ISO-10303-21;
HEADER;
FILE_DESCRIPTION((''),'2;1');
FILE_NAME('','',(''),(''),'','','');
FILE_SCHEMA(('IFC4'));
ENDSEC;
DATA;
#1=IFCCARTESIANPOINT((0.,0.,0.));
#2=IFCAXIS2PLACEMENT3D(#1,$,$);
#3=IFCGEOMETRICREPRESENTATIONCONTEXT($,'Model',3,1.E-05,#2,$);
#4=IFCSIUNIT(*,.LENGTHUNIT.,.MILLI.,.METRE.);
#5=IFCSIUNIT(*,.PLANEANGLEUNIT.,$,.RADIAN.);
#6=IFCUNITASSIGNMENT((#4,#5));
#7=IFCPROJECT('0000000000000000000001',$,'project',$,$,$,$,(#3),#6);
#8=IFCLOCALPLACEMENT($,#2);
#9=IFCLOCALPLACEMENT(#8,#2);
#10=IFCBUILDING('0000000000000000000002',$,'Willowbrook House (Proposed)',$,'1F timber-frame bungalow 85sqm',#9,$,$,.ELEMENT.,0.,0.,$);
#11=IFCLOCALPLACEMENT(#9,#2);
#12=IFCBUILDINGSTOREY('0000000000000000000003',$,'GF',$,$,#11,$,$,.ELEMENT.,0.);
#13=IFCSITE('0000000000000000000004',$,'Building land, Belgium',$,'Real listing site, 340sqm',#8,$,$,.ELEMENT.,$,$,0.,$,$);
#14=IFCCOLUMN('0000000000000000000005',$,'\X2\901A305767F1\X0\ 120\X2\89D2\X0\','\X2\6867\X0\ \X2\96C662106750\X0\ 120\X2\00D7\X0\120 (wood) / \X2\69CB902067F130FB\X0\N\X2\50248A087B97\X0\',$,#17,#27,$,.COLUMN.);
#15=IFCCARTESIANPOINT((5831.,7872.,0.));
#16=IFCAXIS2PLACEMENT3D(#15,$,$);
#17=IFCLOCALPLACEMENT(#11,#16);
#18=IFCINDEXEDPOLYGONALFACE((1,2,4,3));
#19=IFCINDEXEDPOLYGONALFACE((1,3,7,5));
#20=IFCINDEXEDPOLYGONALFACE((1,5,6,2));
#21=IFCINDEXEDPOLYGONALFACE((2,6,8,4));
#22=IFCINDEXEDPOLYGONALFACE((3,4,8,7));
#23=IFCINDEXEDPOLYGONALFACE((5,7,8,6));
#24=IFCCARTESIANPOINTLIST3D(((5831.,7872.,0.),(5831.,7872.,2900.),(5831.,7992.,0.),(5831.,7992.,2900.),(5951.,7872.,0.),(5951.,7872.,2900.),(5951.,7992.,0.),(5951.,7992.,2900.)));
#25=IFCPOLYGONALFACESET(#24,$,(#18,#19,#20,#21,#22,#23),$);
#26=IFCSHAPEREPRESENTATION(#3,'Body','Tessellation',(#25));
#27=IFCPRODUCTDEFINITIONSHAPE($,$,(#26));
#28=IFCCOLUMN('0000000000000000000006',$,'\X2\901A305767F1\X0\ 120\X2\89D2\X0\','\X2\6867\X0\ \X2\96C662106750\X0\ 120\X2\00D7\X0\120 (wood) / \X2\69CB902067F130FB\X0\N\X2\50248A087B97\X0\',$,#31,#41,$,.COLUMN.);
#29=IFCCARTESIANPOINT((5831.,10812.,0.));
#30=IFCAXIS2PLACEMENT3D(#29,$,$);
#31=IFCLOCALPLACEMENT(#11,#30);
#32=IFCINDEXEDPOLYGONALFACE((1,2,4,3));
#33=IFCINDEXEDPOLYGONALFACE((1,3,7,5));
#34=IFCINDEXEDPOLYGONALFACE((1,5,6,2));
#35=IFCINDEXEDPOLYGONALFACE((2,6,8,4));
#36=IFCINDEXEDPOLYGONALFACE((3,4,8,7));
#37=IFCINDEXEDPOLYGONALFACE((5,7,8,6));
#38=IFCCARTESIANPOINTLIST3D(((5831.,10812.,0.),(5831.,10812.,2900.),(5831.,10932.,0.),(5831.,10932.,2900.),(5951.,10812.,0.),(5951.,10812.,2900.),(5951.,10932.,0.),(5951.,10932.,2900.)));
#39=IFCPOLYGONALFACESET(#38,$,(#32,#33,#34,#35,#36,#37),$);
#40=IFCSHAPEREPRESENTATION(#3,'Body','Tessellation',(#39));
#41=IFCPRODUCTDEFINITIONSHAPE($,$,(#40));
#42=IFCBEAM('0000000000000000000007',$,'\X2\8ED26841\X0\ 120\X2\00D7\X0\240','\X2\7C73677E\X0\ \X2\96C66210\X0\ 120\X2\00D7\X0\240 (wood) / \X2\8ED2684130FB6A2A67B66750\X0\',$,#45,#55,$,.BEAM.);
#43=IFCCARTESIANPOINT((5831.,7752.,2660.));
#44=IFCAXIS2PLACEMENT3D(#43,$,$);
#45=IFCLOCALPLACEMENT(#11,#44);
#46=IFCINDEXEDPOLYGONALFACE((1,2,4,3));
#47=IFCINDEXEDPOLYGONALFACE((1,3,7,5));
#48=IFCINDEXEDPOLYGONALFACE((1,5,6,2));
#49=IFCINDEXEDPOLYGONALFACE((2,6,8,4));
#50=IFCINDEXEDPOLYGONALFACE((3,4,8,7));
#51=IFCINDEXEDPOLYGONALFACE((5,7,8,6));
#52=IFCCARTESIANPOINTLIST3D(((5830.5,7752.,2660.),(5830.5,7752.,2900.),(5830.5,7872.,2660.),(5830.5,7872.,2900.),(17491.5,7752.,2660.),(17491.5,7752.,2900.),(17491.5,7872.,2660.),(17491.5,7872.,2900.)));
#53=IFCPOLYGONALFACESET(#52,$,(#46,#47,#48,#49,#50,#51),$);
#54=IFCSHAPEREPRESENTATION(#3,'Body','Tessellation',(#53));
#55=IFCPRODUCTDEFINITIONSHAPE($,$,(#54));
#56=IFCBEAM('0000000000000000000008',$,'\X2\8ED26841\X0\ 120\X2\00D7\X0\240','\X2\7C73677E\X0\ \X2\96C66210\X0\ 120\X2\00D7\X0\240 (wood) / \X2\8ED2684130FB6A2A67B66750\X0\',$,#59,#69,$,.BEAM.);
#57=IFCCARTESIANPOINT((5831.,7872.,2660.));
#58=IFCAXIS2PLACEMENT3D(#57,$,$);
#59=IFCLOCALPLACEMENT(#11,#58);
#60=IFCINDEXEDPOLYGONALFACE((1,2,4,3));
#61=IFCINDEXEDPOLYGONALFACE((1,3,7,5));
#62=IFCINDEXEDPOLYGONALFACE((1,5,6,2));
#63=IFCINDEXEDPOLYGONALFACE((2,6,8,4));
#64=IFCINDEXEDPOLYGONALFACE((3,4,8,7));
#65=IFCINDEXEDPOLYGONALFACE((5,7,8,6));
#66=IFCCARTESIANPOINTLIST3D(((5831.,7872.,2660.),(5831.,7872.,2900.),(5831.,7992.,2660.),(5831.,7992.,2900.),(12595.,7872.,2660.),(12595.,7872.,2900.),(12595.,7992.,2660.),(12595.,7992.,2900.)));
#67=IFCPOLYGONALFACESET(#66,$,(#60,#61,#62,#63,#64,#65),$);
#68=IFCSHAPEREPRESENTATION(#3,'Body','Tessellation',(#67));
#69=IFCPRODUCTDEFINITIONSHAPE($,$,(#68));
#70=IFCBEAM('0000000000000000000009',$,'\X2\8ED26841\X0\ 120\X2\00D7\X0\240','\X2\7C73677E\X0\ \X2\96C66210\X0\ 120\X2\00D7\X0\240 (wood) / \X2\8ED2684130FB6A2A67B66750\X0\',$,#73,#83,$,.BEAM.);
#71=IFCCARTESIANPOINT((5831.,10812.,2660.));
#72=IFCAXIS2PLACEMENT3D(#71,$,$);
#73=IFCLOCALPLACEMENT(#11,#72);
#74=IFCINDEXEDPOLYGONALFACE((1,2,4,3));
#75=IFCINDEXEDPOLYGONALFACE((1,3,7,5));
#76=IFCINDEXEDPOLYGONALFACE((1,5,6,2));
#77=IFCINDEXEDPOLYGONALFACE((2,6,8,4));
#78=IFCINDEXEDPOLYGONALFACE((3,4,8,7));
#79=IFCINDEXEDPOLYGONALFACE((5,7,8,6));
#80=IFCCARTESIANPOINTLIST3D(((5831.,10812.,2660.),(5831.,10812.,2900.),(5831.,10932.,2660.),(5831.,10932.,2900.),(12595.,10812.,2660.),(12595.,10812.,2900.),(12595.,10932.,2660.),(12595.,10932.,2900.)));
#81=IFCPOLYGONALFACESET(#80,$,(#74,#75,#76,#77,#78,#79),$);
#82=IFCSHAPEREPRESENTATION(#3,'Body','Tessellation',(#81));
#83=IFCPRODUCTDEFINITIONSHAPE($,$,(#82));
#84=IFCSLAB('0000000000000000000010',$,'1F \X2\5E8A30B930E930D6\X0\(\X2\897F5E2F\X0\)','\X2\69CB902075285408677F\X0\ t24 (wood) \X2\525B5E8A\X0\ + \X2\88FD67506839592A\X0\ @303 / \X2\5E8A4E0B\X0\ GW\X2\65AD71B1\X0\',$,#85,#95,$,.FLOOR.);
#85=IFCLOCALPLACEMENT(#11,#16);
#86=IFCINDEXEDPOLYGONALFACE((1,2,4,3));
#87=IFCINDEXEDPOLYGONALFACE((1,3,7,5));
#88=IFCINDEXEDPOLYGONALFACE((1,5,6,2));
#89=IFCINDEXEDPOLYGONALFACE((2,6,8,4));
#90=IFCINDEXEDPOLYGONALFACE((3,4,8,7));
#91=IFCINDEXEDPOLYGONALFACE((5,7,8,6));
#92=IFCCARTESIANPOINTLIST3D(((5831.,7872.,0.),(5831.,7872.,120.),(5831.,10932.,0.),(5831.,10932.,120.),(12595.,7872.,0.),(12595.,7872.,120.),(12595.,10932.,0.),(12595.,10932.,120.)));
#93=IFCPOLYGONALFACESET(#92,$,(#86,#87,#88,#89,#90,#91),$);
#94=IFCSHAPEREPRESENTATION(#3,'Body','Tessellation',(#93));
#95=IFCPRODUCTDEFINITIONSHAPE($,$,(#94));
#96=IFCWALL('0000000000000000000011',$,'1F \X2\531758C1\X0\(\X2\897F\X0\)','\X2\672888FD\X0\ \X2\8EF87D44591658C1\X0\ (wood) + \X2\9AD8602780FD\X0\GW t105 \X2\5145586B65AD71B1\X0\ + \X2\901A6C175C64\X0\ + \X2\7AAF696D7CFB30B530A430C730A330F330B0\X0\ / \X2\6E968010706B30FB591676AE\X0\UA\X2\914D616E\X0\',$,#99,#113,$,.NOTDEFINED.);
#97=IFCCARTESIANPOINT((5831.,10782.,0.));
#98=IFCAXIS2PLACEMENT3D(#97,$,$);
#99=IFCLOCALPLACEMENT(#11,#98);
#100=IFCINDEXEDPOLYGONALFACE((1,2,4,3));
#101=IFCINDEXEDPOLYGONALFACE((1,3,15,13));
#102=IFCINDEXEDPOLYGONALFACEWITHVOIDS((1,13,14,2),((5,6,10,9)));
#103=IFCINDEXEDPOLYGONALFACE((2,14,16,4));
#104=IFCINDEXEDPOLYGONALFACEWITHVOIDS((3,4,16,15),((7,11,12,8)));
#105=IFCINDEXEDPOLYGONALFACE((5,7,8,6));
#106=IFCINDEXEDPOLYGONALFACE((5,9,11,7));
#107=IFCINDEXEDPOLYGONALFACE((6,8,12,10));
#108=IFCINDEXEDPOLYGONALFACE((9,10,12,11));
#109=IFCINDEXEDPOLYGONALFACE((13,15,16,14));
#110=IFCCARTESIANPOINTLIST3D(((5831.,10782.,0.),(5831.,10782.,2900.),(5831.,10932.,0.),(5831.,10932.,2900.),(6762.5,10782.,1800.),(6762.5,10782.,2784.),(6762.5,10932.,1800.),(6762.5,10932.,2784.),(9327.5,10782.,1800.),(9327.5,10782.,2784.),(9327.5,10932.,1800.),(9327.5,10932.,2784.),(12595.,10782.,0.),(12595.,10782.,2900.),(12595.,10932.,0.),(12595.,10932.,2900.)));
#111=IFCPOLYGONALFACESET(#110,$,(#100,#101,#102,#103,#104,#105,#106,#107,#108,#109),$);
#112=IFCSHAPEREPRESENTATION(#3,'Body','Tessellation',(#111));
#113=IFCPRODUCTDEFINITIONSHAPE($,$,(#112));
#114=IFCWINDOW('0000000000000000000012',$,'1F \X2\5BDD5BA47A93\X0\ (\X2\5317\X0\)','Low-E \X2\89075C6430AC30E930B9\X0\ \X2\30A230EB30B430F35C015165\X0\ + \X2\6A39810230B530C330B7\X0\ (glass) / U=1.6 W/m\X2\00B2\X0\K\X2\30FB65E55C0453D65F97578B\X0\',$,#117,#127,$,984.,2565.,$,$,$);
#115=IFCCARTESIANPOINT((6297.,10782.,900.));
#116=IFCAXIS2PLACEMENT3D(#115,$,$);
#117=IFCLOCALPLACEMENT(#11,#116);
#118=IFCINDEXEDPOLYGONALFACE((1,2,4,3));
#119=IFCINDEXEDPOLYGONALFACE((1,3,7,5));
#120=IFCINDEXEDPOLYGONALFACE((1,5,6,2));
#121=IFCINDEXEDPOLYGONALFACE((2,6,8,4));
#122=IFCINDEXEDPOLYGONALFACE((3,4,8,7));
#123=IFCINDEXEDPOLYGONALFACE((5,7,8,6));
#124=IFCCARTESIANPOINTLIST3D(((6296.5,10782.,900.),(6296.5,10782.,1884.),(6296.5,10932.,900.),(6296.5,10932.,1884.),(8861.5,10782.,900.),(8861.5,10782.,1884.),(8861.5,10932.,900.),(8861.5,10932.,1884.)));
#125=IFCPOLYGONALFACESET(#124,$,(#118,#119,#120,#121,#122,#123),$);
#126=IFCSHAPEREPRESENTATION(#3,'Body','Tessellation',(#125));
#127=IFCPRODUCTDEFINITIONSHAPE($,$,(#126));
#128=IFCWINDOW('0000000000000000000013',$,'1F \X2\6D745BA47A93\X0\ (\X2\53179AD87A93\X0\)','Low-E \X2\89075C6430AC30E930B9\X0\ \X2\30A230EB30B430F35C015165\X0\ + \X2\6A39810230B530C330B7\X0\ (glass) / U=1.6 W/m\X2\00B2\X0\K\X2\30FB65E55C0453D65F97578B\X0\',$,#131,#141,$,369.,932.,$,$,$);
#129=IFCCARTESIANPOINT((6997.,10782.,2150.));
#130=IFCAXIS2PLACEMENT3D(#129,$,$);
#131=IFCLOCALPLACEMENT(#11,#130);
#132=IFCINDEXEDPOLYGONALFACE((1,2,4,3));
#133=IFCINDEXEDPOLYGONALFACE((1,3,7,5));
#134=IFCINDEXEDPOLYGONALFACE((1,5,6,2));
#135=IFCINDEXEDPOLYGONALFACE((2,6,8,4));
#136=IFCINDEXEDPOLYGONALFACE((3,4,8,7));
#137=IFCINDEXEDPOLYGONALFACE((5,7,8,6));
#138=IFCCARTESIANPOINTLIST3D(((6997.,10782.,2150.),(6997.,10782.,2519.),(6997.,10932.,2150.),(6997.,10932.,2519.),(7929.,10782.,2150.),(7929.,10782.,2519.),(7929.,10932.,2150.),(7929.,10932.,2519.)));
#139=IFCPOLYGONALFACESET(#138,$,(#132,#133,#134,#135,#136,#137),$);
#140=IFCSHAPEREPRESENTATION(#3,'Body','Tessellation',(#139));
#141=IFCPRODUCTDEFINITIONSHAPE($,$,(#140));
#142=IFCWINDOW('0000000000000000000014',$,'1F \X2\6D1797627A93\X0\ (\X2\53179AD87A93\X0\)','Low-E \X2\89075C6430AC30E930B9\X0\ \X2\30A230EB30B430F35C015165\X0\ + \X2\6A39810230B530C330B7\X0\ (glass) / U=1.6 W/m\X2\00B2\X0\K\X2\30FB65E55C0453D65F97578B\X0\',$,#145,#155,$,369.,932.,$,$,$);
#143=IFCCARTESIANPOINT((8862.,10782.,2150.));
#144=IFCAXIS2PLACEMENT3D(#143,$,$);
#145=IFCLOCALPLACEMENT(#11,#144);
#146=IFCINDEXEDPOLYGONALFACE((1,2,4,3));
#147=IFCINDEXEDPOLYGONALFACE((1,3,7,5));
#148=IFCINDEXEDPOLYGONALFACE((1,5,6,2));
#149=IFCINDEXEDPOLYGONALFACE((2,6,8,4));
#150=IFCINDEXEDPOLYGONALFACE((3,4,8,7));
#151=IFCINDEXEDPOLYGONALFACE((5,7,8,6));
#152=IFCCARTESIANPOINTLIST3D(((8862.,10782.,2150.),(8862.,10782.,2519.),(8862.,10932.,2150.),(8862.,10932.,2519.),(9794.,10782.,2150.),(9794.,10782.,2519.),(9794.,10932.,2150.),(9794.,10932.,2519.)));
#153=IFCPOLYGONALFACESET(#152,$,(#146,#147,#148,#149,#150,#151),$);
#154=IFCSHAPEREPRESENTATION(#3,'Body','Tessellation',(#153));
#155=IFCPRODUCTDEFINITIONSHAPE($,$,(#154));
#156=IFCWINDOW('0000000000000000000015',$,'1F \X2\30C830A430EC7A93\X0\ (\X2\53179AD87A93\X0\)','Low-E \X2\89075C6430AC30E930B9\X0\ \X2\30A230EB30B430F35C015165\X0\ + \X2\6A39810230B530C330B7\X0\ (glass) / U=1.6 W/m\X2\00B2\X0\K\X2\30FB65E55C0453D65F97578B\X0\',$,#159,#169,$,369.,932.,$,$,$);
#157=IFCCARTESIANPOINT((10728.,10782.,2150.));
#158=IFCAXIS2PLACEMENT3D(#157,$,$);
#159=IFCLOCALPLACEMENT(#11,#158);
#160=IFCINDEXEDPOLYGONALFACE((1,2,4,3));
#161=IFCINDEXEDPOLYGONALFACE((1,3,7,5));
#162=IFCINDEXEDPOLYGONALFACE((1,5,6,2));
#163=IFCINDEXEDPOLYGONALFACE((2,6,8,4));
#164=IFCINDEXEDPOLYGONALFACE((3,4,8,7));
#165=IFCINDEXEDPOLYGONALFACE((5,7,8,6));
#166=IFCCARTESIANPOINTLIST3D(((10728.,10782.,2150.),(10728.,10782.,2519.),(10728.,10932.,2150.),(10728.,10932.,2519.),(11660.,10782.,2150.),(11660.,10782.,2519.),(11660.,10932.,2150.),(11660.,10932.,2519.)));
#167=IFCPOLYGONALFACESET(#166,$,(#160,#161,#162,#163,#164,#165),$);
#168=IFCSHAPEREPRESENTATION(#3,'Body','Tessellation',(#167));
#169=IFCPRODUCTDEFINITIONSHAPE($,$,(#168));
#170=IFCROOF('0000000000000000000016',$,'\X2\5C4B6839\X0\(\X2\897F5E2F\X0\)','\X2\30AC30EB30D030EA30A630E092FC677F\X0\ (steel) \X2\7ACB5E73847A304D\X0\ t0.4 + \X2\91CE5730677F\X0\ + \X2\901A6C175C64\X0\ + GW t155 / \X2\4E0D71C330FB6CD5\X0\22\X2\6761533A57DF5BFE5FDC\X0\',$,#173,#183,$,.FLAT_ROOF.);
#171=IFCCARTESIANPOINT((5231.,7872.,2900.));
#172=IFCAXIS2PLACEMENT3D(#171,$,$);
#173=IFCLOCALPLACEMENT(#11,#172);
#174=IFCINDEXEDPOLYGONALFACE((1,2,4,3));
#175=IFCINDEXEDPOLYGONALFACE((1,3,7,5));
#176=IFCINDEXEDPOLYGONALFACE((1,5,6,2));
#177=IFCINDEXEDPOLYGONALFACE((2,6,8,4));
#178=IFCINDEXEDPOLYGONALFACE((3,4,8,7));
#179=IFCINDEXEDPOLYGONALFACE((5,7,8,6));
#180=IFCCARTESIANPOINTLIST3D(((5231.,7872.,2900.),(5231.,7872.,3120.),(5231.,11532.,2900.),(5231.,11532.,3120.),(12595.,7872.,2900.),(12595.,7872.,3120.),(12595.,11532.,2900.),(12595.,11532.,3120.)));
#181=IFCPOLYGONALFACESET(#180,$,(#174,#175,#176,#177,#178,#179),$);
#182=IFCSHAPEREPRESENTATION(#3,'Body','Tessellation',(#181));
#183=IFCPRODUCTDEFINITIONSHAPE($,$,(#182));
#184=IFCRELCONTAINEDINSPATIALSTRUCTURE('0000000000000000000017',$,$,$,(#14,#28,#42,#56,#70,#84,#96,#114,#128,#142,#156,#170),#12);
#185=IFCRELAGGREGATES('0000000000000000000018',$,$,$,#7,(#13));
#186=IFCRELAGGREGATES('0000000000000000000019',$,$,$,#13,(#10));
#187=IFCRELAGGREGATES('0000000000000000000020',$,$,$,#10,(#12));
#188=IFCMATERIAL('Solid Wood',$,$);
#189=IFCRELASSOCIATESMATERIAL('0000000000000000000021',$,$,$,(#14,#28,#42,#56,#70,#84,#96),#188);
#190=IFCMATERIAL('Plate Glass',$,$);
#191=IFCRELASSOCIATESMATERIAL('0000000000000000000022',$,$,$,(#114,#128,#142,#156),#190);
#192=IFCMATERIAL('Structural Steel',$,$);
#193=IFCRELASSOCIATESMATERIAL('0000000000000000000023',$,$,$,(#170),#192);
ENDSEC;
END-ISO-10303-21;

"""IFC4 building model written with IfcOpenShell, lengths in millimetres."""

from ifc_helpers import new_model, si_unit, frame, frame_2d, origin, place, context, project, spatial, rectangle, extrude, material, element, fill, save


model = new_model("IFC4")

# Units and contexts
model_context = context("Model", 3, precision=1e-05, world=origin())
ifc_project = project(units=[si_unit("LENGTHUNIT", "METRE", prefix="MILLI"), si_unit("PLANEANGLEUNIT", "RADIAN")], contexts=[model_context])

# Site, building, storey
site_placement = place(None, origin())
site = spatial("IfcSite", under=ifc_project, at=site_placement, Name="Building land, Belgium", ObjectType="Real listing site, 340sqm", CompositionType="ELEMENT", RefElevation=0.0)
building_placement = place(site_placement, origin())
building = spatial("IfcBuilding", under=site, at=building_placement, Name="Willowbrook House (Proposed)", ObjectType="1F timber-frame bungalow 85sqm", CompositionType="ELEMENT", ElevationOfRefHeight=0.0, ElevationOfTerrain=0.0)
storey_placement = place(building_placement, origin())
storey = spatial("IfcBuildingStorey", under=building, at=storey_placement, Name="GF", CompositionType="ELEMENT", Elevation=0.0)

# Columns
ifc_material_1 = material(Name="Solid Wood")
column_1_placement = place(storey_placement, frame((5831.0, 7872.0, 0.0)))
element("IfcColumn", 1, at=column_1_placement, inside=storey, material=ifc_material_1, Name="通し柱 120角", Description="桧 集成材 120×120 (wood) / 構造柱・N値計算", PredefinedType="COLUMN", context=model_context, shape_type="SweptSolid", body=[
    extrude(rectangle(XDim=120.0, YDim=120.0, at=frame_2d((60.0, 60.0))), frame((5831.0, 7872.0, 0.0)), (0.0, 0.0, 1.0), 2900.0),
])
column_2_placement = place(storey_placement, frame((5831.0, 10812.0, 0.0)))
element("IfcColumn", 2, at=column_2_placement, inside=storey, material=ifc_material_1, Name="通し柱 120角", Description="桧 集成材 120×120 (wood) / 構造柱・N値計算", PredefinedType="COLUMN", context=model_context, shape_type="SweptSolid", body=[
    extrude(rectangle(XDim=120.0, YDim=120.0, at=frame_2d((60.0, 60.0))), frame((5831.0, 10812.0, 0.0)), (0.0, 0.0, 1.0), 2900.0),
])

# Beams
beam_1_placement = place(storey_placement, frame((5831.0, 7752.0, 2660.0)))
element("IfcBeam", 3, at=beam_1_placement, inside=storey, material=ifc_material_1, Name="軒桁 120×240", Description="米松 集成 120×240 (wood) / 軒桁・横架材", PredefinedType="BEAM", context=model_context, shape_type="SweptSolid", body=[
    extrude(rectangle(XDim=11661.0, YDim=120.0, at=frame_2d((5830.0, 60.0))), frame((5831.0, 7752.0, 2660.0)), (0.0, 0.0, 1.0), 240.0),
])
beam_2_placement = place(storey_placement, frame((5831.0, 7872.0, 2660.0)))
element("IfcBeam", 4, at=beam_2_placement, inside=storey, material=ifc_material_1, Name="軒桁 120×240", Description="米松 集成 120×240 (wood) / 軒桁・横架材", PredefinedType="BEAM", context=model_context, shape_type="SweptSolid", body=[
    extrude(rectangle(XDim=6764.0, YDim=120.0, at=frame_2d((3382.0, 60.0))), frame((5831.0, 7872.0, 2660.0)), (0.0, 0.0, 1.0), 240.0),
])
beam_3_placement = place(storey_placement, frame((5831.0, 10812.0, 2660.0)))
element("IfcBeam", 5, at=beam_3_placement, inside=storey, material=ifc_material_1, Name="軒桁 120×240", Description="米松 集成 120×240 (wood) / 軒桁・横架材", PredefinedType="BEAM", context=model_context, shape_type="SweptSolid", body=[
    extrude(rectangle(XDim=6764.0, YDim=120.0, at=frame_2d((3382.0, 60.0))), frame((5831.0, 10812.0, 2660.0)), (0.0, 0.0, 1.0), 240.0),
])

# Slab
slab_placement = place(storey_placement, frame((5831.0, 7872.0, 0.0)))
element("IfcSlab", 6, at=slab_placement, inside=storey, material=ifc_material_1, Name="1F 床スラブ(西帯)", Description="構造用合板 t24 (wood) 剛床 + 製材根太 @303 / 床下 GW断熱", PredefinedType="FLOOR", context=model_context, shape_type="SweptSolid", body=[
    extrude(rectangle(XDim=6764.0, YDim=3060.0, at=frame_2d((3382.0, 1530.0))), frame((5831.0, 7872.0, 0.0)), (0.0, 0.0, 1.0), 120.0),
])

# Wall, openings, windows
wall_1_placement = place(storey_placement, frame((5831.0, 10782.0, 0.0)))
wall_1 = element("IfcWall", 7, at=wall_1_placement, inside=storey, material=ifc_material_1, Name="1F 北壁(西)", Description="木製 軸組外壁 (wood) + 高性能GW t105 充填断熱 + 通気層 + 窯業系サイディング / 準耐火・外皮UA配慮", PredefinedType="NOTDEFINED", context=model_context, shape_type="SweptSolid", body=[
    extrude(rectangle(XDim=6764.0, YDim=150.0, at=frame_2d((3382.0, 75.0))), frame((5831.0, 10782.0, 0.0)), (0.0, 0.0, 1.0), 2900.0),
])
opening_1_placement = place(storey_placement, frame((6297.0, 10782.0, 900.0)))
opening_1 = element("IfcOpeningElement", 8, at=opening_1_placement, cuts=wall_1, PredefinedType="NOTDEFINED", context=model_context, shape_type="SweptSolid", body=[
    extrude(rectangle(XDim=2565.0, YDim=150.0, at=frame_2d((1282.0, 75.0))), frame((6297.0, 10782.0, 900.0)), (0.0, 0.0, 1.0), 984.0),
])
opening_2_placement = place(storey_placement, frame((6997.0, 10782.0, 2150.0)))
opening_2 = element("IfcOpeningElement", 9, at=opening_2_placement, cuts=wall_1, PredefinedType="NOTDEFINED", context=model_context, shape_type="SweptSolid", body=[
    extrude(rectangle(XDim=932.0, YDim=150.0, at=frame_2d((466.0, 75.0))), frame((6997.0, 10782.0, 2150.0)), (0.0, 0.0, 1.0), 369.0),
])
opening_3_placement = place(storey_placement, frame((8862.0, 10782.0, 2150.0)))
opening_3 = element("IfcOpeningElement", 10, at=opening_3_placement, cuts=wall_1, PredefinedType="NOTDEFINED", context=model_context, shape_type="SweptSolid", body=[
    extrude(rectangle(XDim=932.0, YDim=150.0, at=frame_2d((466.0, 75.0))), frame((8862.0, 10782.0, 2150.0)), (0.0, 0.0, 1.0), 369.0),
])
opening_4_placement = place(storey_placement, frame((10728.0, 10782.0, 2150.0)))
opening_4 = element("IfcOpeningElement", 11, at=opening_4_placement, cuts=wall_1, PredefinedType="NOTDEFINED", context=model_context, shape_type="SweptSolid", body=[
    extrude(rectangle(XDim=932.0, YDim=150.0, at=frame_2d((466.0, 75.0))), frame((10728.0, 10782.0, 2150.0)), (0.0, 0.0, 1.0), 369.0),
])
ifc_material_2 = material(Name="Plate Glass")
window_1_placement = place(storey_placement, frame((6297.0, 10782.0, 900.0)))
window_1 = element("IfcWindow", 12, at=window_1_placement, inside=storey, material=ifc_material_2, Name="1F 寝室窓 (北)", Description="Low-E 複層ガラス アルゴン封入 + 樹脂サッシ (glass) / U=1.6 W/m²K・日射取得型", OverallHeight=984.0, OverallWidth=2565.0, context=model_context, shape_type="SweptSolid", body=[
    extrude(rectangle(XDim=2565.0, YDim=150.0, at=frame_2d((1282.0, 75.0))), frame((6297.0, 10782.0, 900.0)), (0.0, 0.0, 1.0), 984.0),
])
fill(opening_1, window_1)
window_2_placement = place(storey_placement, frame((6997.0, 10782.0, 2150.0)))
window_2 = element("IfcWindow", 13, at=window_2_placement, inside=storey, material=ifc_material_2, Name="1F 浴室窓 (北高窓)", Description="Low-E 複層ガラス アルゴン封入 + 樹脂サッシ (glass) / U=1.6 W/m²K・日射取得型", OverallHeight=369.0, OverallWidth=932.0, context=model_context, shape_type="SweptSolid", body=[
    extrude(rectangle(XDim=932.0, YDim=150.0, at=frame_2d((466.0, 75.0))), frame((6997.0, 10782.0, 2150.0)), (0.0, 0.0, 1.0), 369.0),
])
fill(opening_2, window_2)
window_3_placement = place(storey_placement, frame((8862.0, 10782.0, 2150.0)))
window_3 = element("IfcWindow", 14, at=window_3_placement, inside=storey, material=ifc_material_2, Name="1F 洗面窓 (北高窓)", Description="Low-E 複層ガラス アルゴン封入 + 樹脂サッシ (glass) / U=1.6 W/m²K・日射取得型", OverallHeight=369.0, OverallWidth=932.0, context=model_context, shape_type="SweptSolid", body=[
    extrude(rectangle(XDim=932.0, YDim=150.0, at=frame_2d((466.0, 75.0))), frame((8862.0, 10782.0, 2150.0)), (0.0, 0.0, 1.0), 369.0),
])
fill(opening_3, window_3)
window_4_placement = place(storey_placement, frame((10728.0, 10782.0, 2150.0)))
window_4 = element("IfcWindow", 15, at=window_4_placement, inside=storey, material=ifc_material_2, Name="1F トイレ窓 (北高窓)", Description="Low-E 複層ガラス アルゴン封入 + 樹脂サッシ (glass) / U=1.6 W/m²K・日射取得型", OverallHeight=369.0, OverallWidth=932.0, context=model_context, shape_type="SweptSolid", body=[
    extrude(rectangle(XDim=932.0, YDim=150.0, at=frame_2d((466.0, 75.0))), frame((10728.0, 10782.0, 2150.0)), (0.0, 0.0, 1.0), 369.0),
])
fill(opening_4, window_4)

# Roof
ifc_material_3 = material(Name="Structural Steel")
roof_placement = place(storey_placement, frame((5231.0, 7872.0, 2900.0)))
element("IfcRoof", 16, at=roof_placement, inside=storey, material=ifc_material_3, Name="屋根(西帯)", Description="ガルバリウム鋼板 (steel) 立平葺き t0.4 + 野地板 + 通気層 + GW t155 / 不燃・法22条区域対応", PredefinedType="FLAT_ROOF", context=model_context, shape_type="SweptSolid", body=[
    extrude(rectangle(XDim=7364.0, YDim=3660.0, at=frame_2d((3682.0, 1830.0))), frame((5231.0, 7872.0, 2900.0)), (0.0, 0.0, 1.0), 220.0),
])

save(model, "model.ifc")
